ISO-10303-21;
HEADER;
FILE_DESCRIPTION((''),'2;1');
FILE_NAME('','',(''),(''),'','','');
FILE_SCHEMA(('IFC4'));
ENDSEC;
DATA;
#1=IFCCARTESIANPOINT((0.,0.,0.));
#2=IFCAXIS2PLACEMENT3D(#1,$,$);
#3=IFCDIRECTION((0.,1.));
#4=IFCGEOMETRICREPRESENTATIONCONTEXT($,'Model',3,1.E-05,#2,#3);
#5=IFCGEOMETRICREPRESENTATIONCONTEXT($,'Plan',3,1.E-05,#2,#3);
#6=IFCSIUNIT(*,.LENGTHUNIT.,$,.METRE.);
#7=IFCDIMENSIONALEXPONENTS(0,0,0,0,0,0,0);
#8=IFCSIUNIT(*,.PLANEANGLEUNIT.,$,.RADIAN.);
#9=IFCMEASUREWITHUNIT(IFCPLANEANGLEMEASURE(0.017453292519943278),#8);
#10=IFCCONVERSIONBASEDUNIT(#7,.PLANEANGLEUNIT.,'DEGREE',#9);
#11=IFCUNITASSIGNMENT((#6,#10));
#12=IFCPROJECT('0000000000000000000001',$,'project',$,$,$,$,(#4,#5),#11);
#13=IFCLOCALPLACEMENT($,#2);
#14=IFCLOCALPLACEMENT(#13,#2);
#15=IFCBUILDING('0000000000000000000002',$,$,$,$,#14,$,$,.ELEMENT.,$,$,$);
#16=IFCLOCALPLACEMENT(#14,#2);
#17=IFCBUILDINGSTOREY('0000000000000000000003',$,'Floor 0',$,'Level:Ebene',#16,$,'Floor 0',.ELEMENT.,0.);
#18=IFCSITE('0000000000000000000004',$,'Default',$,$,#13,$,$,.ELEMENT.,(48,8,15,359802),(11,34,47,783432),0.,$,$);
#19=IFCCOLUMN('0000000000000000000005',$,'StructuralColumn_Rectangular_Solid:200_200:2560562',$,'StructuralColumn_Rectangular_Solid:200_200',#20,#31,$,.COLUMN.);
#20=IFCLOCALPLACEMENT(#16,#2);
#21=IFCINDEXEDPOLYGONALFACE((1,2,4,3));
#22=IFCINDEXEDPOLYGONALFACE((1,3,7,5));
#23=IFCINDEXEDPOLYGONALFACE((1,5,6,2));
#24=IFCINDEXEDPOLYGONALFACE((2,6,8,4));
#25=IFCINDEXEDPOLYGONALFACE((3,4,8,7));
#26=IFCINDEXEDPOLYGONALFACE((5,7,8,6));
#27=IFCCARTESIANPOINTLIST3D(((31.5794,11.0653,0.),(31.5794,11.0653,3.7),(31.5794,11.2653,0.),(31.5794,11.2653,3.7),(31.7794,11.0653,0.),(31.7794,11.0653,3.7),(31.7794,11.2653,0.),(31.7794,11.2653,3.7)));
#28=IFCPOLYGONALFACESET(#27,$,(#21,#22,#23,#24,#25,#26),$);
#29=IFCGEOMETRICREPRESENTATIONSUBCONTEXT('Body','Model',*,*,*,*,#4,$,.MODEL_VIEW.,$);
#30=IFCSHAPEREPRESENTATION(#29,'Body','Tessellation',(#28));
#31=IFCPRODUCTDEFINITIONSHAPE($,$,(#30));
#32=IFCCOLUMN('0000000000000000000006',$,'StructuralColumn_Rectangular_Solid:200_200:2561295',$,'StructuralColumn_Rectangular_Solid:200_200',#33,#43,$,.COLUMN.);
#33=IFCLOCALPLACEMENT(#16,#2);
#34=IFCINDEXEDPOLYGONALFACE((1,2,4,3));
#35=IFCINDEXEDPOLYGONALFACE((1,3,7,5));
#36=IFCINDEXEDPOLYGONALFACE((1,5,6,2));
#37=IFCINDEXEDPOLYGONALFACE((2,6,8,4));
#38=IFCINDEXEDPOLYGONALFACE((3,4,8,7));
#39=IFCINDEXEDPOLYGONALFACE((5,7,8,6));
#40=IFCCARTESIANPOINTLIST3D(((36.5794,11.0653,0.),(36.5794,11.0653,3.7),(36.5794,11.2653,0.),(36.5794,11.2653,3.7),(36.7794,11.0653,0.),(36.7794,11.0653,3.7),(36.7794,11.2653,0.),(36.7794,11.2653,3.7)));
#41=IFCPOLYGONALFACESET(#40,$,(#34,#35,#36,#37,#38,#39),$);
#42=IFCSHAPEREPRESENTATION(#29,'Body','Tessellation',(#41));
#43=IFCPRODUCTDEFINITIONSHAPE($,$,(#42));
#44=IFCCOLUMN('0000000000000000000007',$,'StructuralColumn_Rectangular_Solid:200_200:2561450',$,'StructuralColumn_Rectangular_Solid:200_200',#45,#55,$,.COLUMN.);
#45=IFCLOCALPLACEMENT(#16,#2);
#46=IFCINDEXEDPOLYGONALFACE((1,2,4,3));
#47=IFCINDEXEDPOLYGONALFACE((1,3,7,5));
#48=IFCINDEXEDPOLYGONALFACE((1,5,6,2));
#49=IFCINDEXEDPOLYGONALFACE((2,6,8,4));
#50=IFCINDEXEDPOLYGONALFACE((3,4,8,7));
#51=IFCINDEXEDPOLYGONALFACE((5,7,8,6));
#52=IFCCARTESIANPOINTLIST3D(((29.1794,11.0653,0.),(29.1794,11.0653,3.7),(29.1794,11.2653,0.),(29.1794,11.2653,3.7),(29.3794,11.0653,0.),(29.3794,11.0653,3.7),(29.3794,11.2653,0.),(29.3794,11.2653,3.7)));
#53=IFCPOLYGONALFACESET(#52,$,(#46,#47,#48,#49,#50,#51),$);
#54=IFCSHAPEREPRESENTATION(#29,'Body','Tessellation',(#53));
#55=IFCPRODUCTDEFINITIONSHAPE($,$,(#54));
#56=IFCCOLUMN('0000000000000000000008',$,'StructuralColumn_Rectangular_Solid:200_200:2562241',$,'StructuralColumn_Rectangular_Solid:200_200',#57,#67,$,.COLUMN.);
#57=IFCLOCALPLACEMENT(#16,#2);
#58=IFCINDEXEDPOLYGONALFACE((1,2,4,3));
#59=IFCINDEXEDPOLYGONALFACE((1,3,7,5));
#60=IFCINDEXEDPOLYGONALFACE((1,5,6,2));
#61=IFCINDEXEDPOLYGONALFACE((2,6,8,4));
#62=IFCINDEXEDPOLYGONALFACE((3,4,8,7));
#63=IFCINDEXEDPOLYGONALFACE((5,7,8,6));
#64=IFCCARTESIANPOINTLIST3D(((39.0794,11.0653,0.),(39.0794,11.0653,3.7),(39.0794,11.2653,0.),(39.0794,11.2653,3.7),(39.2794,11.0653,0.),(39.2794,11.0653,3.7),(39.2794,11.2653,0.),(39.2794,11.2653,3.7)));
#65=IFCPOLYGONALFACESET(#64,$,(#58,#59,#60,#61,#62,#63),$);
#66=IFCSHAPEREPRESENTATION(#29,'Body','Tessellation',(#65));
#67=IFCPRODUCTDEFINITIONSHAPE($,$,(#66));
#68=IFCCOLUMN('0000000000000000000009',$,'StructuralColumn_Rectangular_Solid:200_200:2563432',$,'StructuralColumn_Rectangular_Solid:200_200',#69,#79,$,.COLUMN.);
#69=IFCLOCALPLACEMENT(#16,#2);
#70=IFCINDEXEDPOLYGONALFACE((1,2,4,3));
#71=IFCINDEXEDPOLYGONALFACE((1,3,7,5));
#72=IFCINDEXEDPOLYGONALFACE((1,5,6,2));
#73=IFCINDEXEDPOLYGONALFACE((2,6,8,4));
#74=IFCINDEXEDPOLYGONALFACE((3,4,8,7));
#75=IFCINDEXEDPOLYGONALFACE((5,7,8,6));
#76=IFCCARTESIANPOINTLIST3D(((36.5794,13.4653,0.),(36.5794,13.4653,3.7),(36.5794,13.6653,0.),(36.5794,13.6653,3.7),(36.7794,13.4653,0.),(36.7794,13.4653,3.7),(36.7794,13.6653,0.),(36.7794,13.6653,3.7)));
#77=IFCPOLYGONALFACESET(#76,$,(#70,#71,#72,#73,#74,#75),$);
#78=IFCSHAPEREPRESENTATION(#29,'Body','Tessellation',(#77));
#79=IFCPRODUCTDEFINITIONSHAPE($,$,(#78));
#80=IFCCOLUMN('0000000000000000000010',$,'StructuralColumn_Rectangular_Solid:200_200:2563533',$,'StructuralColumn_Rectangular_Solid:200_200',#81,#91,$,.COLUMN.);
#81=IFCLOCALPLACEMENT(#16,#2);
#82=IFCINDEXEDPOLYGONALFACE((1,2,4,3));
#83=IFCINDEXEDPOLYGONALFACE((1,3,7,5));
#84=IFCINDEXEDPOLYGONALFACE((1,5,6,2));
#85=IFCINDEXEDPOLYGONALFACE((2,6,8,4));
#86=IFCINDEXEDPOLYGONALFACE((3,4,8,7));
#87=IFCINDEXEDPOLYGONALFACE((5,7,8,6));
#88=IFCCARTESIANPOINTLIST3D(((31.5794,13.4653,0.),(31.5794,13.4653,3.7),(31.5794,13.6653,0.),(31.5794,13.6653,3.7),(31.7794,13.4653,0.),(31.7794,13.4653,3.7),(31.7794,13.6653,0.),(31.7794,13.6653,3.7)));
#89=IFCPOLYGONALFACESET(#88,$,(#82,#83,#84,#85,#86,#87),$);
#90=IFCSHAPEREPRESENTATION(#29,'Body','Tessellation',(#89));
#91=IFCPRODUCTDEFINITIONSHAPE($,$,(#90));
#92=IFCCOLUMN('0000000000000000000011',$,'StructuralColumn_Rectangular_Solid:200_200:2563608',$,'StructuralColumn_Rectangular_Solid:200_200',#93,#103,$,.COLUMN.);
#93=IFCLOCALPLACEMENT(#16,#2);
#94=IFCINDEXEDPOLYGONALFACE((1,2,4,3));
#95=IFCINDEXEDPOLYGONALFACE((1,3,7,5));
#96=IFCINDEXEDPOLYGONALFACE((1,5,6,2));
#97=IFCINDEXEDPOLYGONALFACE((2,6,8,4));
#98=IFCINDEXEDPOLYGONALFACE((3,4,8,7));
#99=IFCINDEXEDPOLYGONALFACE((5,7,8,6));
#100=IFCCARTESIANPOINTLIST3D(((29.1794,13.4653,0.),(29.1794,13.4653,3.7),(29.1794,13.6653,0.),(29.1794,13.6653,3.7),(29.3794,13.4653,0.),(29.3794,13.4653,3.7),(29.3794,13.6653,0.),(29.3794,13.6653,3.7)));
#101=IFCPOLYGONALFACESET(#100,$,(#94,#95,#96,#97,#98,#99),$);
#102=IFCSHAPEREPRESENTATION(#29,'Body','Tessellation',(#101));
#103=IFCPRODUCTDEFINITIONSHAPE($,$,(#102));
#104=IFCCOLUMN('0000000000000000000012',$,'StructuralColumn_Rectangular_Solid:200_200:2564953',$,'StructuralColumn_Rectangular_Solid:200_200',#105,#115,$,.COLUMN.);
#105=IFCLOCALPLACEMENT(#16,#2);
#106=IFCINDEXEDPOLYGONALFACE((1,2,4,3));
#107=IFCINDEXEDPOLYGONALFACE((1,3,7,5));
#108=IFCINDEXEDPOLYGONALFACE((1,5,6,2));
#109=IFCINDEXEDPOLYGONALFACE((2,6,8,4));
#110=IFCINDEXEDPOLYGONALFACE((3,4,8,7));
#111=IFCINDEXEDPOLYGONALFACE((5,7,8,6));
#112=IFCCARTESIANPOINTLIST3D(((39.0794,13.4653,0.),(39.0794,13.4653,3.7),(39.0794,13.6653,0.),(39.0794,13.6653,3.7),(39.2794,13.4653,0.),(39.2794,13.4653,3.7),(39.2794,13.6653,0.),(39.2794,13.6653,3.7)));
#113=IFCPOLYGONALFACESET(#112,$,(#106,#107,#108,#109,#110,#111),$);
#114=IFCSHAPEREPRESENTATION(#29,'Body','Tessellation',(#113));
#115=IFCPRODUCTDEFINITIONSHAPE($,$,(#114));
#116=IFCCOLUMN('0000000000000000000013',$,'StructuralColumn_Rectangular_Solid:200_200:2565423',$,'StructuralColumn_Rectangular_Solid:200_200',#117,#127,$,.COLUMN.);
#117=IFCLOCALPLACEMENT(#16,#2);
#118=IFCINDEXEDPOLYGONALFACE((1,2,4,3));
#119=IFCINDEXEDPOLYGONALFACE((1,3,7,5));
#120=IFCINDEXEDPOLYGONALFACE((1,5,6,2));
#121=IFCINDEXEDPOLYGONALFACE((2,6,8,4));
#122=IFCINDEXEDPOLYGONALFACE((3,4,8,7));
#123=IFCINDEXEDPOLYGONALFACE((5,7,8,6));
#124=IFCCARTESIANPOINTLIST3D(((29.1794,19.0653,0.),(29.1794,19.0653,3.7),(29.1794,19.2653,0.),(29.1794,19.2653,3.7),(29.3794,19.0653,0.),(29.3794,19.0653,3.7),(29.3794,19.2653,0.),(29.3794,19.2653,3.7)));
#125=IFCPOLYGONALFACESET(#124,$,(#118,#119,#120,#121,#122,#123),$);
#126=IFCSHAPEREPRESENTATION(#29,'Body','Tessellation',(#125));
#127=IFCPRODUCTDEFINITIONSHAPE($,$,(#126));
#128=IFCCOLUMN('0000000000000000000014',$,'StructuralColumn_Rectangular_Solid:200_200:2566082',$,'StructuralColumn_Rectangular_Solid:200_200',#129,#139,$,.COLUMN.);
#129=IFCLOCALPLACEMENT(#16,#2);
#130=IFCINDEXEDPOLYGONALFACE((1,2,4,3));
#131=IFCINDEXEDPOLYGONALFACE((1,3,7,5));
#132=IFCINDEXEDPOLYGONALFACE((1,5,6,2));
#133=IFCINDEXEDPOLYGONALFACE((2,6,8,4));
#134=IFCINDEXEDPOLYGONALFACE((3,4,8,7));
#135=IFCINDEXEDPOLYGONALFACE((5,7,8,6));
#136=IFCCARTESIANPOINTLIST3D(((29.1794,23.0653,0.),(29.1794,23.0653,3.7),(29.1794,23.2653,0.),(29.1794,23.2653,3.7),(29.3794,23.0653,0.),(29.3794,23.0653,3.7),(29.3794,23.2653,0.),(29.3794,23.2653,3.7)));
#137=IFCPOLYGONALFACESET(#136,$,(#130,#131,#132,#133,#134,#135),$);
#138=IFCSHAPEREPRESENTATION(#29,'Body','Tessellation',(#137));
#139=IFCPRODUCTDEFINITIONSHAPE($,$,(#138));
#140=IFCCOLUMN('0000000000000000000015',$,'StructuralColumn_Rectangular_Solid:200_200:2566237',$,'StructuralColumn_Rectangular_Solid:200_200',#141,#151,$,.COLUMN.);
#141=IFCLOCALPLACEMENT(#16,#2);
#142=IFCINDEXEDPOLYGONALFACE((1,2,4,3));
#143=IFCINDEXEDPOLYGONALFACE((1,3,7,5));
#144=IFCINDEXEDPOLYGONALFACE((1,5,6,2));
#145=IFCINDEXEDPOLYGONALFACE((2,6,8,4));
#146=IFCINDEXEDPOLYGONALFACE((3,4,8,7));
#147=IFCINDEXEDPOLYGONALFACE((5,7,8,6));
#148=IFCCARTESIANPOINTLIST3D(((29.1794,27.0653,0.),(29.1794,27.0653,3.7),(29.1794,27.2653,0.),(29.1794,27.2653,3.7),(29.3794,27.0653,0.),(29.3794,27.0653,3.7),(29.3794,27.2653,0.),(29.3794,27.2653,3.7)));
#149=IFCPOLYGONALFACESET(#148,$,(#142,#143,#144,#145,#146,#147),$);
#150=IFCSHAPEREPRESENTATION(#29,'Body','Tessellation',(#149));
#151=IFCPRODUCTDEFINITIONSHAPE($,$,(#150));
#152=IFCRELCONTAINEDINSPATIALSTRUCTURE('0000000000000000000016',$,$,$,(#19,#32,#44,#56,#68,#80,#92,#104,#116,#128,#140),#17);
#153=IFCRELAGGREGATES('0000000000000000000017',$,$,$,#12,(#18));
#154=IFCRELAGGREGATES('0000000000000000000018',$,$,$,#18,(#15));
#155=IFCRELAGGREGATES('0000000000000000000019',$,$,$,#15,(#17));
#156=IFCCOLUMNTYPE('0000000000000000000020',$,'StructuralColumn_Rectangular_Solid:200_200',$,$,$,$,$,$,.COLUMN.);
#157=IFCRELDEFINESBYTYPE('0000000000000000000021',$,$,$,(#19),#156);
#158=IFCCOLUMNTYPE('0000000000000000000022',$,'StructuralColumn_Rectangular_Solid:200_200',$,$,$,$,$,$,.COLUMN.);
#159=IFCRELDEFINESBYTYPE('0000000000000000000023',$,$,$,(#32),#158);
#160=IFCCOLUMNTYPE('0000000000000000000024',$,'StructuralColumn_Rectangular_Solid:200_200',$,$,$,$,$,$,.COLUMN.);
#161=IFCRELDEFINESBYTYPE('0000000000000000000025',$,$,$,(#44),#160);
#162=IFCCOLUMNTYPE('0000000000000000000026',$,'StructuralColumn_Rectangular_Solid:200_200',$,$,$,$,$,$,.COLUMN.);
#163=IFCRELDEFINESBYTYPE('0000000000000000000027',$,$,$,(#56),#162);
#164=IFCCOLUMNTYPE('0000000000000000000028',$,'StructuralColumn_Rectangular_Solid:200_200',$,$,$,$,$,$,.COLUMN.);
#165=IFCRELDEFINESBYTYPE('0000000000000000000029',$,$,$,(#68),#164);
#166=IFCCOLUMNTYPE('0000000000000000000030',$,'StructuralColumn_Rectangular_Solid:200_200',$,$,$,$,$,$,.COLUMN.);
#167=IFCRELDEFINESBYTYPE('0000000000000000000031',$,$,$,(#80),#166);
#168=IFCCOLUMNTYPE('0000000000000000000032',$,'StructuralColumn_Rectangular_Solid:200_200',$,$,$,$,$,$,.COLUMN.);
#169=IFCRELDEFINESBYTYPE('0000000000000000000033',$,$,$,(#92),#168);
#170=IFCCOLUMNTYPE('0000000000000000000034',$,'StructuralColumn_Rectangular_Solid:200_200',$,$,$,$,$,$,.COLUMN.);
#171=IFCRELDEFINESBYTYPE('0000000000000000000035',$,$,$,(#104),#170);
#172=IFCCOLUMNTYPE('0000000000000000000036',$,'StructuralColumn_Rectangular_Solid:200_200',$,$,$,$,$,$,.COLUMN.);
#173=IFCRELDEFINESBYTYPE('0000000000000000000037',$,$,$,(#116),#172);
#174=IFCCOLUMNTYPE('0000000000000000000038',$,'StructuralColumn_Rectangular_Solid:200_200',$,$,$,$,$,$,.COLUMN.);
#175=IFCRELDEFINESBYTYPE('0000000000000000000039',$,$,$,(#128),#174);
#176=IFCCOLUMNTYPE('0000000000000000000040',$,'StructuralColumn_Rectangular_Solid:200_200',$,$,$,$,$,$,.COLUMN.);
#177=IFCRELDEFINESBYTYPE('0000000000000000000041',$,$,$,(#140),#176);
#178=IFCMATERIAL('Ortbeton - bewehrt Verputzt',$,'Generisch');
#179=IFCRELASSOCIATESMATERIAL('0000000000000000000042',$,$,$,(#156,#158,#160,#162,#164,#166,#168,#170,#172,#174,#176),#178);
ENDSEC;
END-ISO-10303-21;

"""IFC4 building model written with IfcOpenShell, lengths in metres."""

from ifc_helpers import new_model, entity, si_unit, converted_unit, direction, frame, frame_2d, origin, origin_2d_with_axis, place, context, subcontext, project, spatial, rectangle, extrude, source, transform, mapped, material, material_profile, profile_set, type_object, type_shapes, element, save


model = new_model("IFC4")

# Units and contexts
model_context = context("Model", 3, precision=1e-05, world=origin(), true_north=direction((0.0, 1.0)))
plan_context = context("Plan", 3, precision=1e-05, world=origin(), true_north=direction((0.0, 1.0)))
body_context = subcontext(model_context, "Body", "Model", "MODEL_VIEW")
ifc_project = project(units=[si_unit("LENGTHUNIT", "METRE"), converted_unit("PLANEANGLEUNIT", "DEGREE", entity("IfcPlaneAngleMeasure", 0.017453292519943278), si_unit("PLANEANGLEUNIT", "RADIAN"), dimensions=[0, 0, 0, 0, 0, 0, 0])], contexts=[model_context, plan_context])

# Site, building, storey
site_placement = place(None, origin())
site = spatial("IfcSite", under=ifc_project, at=site_placement, Name="Default", CompositionType="ELEMENT", RefLatitude=(48, 8, 15, 359802), RefLongitude=(11, 34, 47, 783432), RefElevation=0.0)
building_placement = place(site_placement, origin())
building = spatial("IfcBuilding", under=site, at=building_placement, CompositionType="ELEMENT")
storey_placement = place(building_placement, origin())
storey = spatial("IfcBuildingStorey", under=building, at=storey_placement, Name="Floor 0", ObjectType="Level:Ebene", LongName="Floor 0", CompositionType="ELEMENT", Elevation=0.0)

# Columns
ifc_material_1 = material(Name="Ortbeton - bewehrt Verputzt", Category="Generisch")
ifc_material_profile = material_profile(ifc_material_1, rectangle(XDim=0.2, YDim=0.2, at=frame_2d((0.0, 0.0), x_axis=(1.0, 0.0))), Name="200_200")
ifc_profile_set = profile_set([ifc_material_profile], Name="200_200")
column_type_1 = type_object("IfcColumnType", Name="StructuralColumn_Rectangular_Solid:200_200", PredefinedType="COLUMN", material=ifc_profile_set)
shared_shape_1 = source(origin(), body_context, "Body", "SweptSolid", [
    extrude(rectangle(XDim=0.2, YDim=0.2, at=frame_2d((0.0, 0.0), x_axis=(1.0, 0.0))), frame((31.6794, 11.1653, 0.0), z_axis=(0.0, 0.0, 1.0), x_axis=(-1.0, 0.0, 0.0)), (0.0, 0.0, 1.0), 3.7),
])
type_shapes(column_type_1, [shared_shape_1])
column_1_placement = place(storey_placement, origin())
element("IfcColumn", 1, at=column_1_placement, inside=storey, type_object=column_type_1, Name="StructuralColumn_Rectangular_Solid:200_200:2560562", ObjectType="StructuralColumn_Rectangular_Solid:200_200", PredefinedType="COLUMN", context=body_context, shape_type="MappedRepresentation", body=[
    mapped(shared_shape_1, transform((0.0, 0.0, 0.0), scale=1.0)),
])
column_type_2 = type_object("IfcColumnType", Name="StructuralColumn_Rectangular_Solid:200_200", PredefinedType="COLUMN", material=ifc_profile_set)
shared_shape_2 = source(origin(), body_context, "Body", "SweptSolid", [
    extrude(rectangle(XDim=0.2, YDim=0.2, at=frame_2d((0.0, 0.0), x_axis=(1.0, 0.0))), frame((36.6794, 11.1653, 0.0), z_axis=(0.0, 0.0, 1.0), x_axis=(-1.0, 0.0, 0.0)), (0.0, 0.0, 1.0), 3.7),
])
type_shapes(column_type_2, [shared_shape_2])
column_2_placement = place(storey_placement, origin())
element("IfcColumn", 2, at=column_2_placement, inside=storey, type_object=column_type_2, Name="StructuralColumn_Rectangular_Solid:200_200:2561295", ObjectType="StructuralColumn_Rectangular_Solid:200_200", PredefinedType="COLUMN", context=body_context, shape_type="MappedRepresentation", body=[
    mapped(shared_shape_2, transform((0.0, 0.0, 0.0), scale=1.0)),
])
column_type_3 = type_object("IfcColumnType", Name="StructuralColumn_Rectangular_Solid:200_200", PredefinedType="COLUMN", material=ifc_profile_set)
shared_shape_3 = source(origin(), body_context, "Body", "SweptSolid", [
    extrude(rectangle(XDim=0.2, YDim=0.2, at=frame_2d((0.0, 0.0), x_axis=(1.0, 0.0))), frame((29.2794, 11.1653, 0.0), z_axis=(0.0, 0.0, 1.0), x_axis=(-1.0, 0.0, 0.0)), (0.0, 0.0, 1.0), 3.7),
])
type_shapes(column_type_3, [shared_shape_3])
column_3_placement = place(storey_placement, origin())
element("IfcColumn", 3, at=column_3_placement, inside=storey, type_object=column_type_3, Name="StructuralColumn_Rectangular_Solid:200_200:2561450", ObjectType="StructuralColumn_Rectangular_Solid:200_200", PredefinedType="COLUMN", context=body_context, shape_type="MappedRepresentation", body=[
    mapped(shared_shape_3, transform((0.0, 0.0, 0.0), scale=1.0)),
])
column_type_4 = type_object("IfcColumnType", Name="StructuralColumn_Rectangular_Solid:200_200", PredefinedType="COLUMN", material=ifc_profile_set)
shared_shape_4 = source(origin(), body_context, "Body", "SweptSolid", [
    extrude(rectangle(XDim=0.2, YDim=0.2, at=frame_2d((0.0, 0.0), x_axis=(1.0, 0.0))), frame((39.1794, 11.1653, 0.0), z_axis=(0.0, 0.0, 1.0), x_axis=(-1.0, 0.0, 0.0)), (0.0, 0.0, 1.0), 3.7),
])
type_shapes(column_type_4, [shared_shape_4])
column_4_placement = place(storey_placement, origin())
element("IfcColumn", 4, at=column_4_placement, inside=storey, type_object=column_type_4, Name="StructuralColumn_Rectangular_Solid:200_200:2562241", ObjectType="StructuralColumn_Rectangular_Solid:200_200", PredefinedType="COLUMN", context=body_context, shape_type="MappedRepresentation", body=[
    mapped(shared_shape_4, transform((0.0, 0.0, 0.0), scale=1.0)),
])
column_type_5 = type_object("IfcColumnType", Name="StructuralColumn_Rectangular_Solid:200_200", PredefinedType="COLUMN", material=ifc_profile_set)
shared_shape_5 = source(origin(), body_context, "Body", "SweptSolid", [
    extrude(rectangle(XDim=0.2, YDim=0.2, at=frame_2d((0.0, 0.0), x_axis=(1.0, 0.0))), frame((36.6794, 13.5653, 0.0), z_axis=(0.0, 0.0, 1.0), x_axis=(-1.0, 0.0, 0.0)), (0.0, 0.0, 1.0), 3.7),
])
type_shapes(column_type_5, [shared_shape_5])
column_5_placement = place(storey_placement, origin())
element("IfcColumn", 5, at=column_5_placement, inside=storey, type_object=column_type_5, Name="StructuralColumn_Rectangular_Solid:200_200:2563432", ObjectType="StructuralColumn_Rectangular_Solid:200_200", PredefinedType="COLUMN", context=body_context, shape_type="MappedRepresentation", body=[
    mapped(shared_shape_5, transform((0.0, 0.0, 0.0), scale=1.0)),
])
column_type_6 = type_object("IfcColumnType", Name="StructuralColumn_Rectangular_Solid:200_200", PredefinedType="COLUMN", material=ifc_profile_set)
shared_shape_6 = source(origin(), body_context, "Body", "SweptSolid", [
    extrude(rectangle(XDim=0.2, YDim=0.2, at=frame_2d((0.0, 0.0), x_axis=(1.0, 0.0))), frame((31.6794, 13.5653, 0.0), z_axis=(0.0, 0.0, 1.0), x_axis=(-1.0, 0.0, 0.0)), (0.0, 0.0, 1.0), 3.7),
])
type_shapes(column_type_6, [shared_shape_6])
column_6_placement = place(storey_placement, origin())
element("IfcColumn", 6, at=column_6_placement, inside=storey, type_object=column_type_6, Name="StructuralColumn_Rectangular_Solid:200_200:2563533", ObjectType="StructuralColumn_Rectangular_Solid:200_200", PredefinedType="COLUMN", context=body_context, shape_type="MappedRepresentation", body=[
    mapped(shared_shape_6, transform((0.0, 0.0, 0.0), scale=1.0)),
])
column_type_7 = type_object("IfcColumnType", Name="StructuralColumn_Rectangular_Solid:200_200", PredefinedType="COLUMN", material=ifc_profile_set)
shared_shape_7 = source(origin(), body_context, "Body", "SweptSolid", [
    extrude(rectangle(XDim=0.2, YDim=0.2, at=frame_2d((0.0, 0.0), x_axis=(1.0, 0.0))), frame((29.2794, 13.5653, 0.0), z_axis=(0.0, 0.0, 1.0), x_axis=(-1.0, 0.0, 0.0)), (0.0, 0.0, 1.0), 3.7),
])
type_shapes(column_type_7, [shared_shape_7])
column_7_placement = place(storey_placement, origin())
element("IfcColumn", 7, at=column_7_placement, inside=storey, type_object=column_type_7, Name="StructuralColumn_Rectangular_Solid:200_200:2563608", ObjectType="StructuralColumn_Rectangular_Solid:200_200", PredefinedType="COLUMN", context=body_context, shape_type="MappedRepresentation", body=[
    mapped(shared_shape_7, transform((0.0, 0.0, 0.0), scale=1.0)),
])
column_type_8 = type_object("IfcColumnType", Name="StructuralColumn_Rectangular_Solid:200_200", PredefinedType="COLUMN", material=ifc_profile_set)
shared_shape_8 = source(origin(), body_context, "Body", "SweptSolid", [
    extrude(rectangle(XDim=0.2, YDim=0.2, at=frame_2d((0.0, 0.0), x_axis=(1.0, 0.0))), frame((39.1794, 13.5653, 0.0), z_axis=(0.0, 0.0, 1.0), x_axis=(-1.0, 0.0, 0.0)), (0.0, 0.0, 1.0), 3.7),
])
type_shapes(column_type_8, [shared_shape_8])
column_8_placement = place(storey_placement, origin())
element("IfcColumn", 8, at=column_8_placement, inside=storey, type_object=column_type_8, Name="StructuralColumn_Rectangular_Solid:200_200:2564953", ObjectType="StructuralColumn_Rectangular_Solid:200_200", PredefinedType="COLUMN", context=body_context, shape_type="MappedRepresentation", body=[
    mapped(shared_shape_8, transform((0.0, 0.0, 0.0), scale=1.0)),
])
column_type_9 = type_object("IfcColumnType", Name="StructuralColumn_Rectangular_Solid:200_200", PredefinedType="COLUMN", material=ifc_profile_set)
shared_shape_9 = source(origin(), body_context, "Body", "SweptSolid", [
    extrude(rectangle(XDim=0.2, YDim=0.2, at=frame_2d((0.0, 0.0), x_axis=(1.0, 0.0))), frame((29.2794, 19.1653, 0.0), z_axis=(0.0, 0.0, 1.0), x_axis=(-1.0, 0.0, 0.0)), (0.0, 0.0, 1.0), 3.7),
])
type_shapes(column_type_9, [shared_shape_9])
column_9_placement = place(storey_placement, origin())
element("IfcColumn", 9, at=column_9_placement, inside=storey, type_object=column_type_9, Name="StructuralColumn_Rectangular_Solid:200_200:2565423", ObjectType="StructuralColumn_Rectangular_Solid:200_200", PredefinedType="COLUMN", context=body_context, shape_type="MappedRepresentation", body=[
    mapped(shared_shape_9, transform((0.0, 0.0, 0.0), scale=1.0)),
])
column_type_10 = type_object("IfcColumnType", Name="StructuralColumn_Rectangular_Solid:200_200", PredefinedType="COLUMN", material=ifc_profile_set)
shared_shape_10 = source(origin(), body_context, "Body", "SweptSolid", [
    extrude(rectangle(XDim=0.2, YDim=0.2, at=origin_2d_with_axis()), frame((29.2794, 23.1653, 0.0), z_axis=(0.0, 0.0, 1.0), x_axis=(-1.0, 0.0, 0.0)), (0.0, 0.0, 1.0), 3.7),
])
type_shapes(column_type_10, [shared_shape_10])
column_10_placement = place(storey_placement, origin())
element("IfcColumn", 10, at=column_10_placement, inside=storey, type_object=column_type_10, Name="StructuralColumn_Rectangular_Solid:200_200:2566082", ObjectType="StructuralColumn_Rectangular_Solid:200_200", PredefinedType="COLUMN", context=body_context, shape_type="MappedRepresentation", body=[
    mapped(shared_shape_10, transform((0.0, 0.0, 0.0), scale=1.0)),
])
column_type_11 = type_object("IfcColumnType", Name="StructuralColumn_Rectangular_Solid:200_200", PredefinedType="COLUMN", material=ifc_profile_set)
shared_shape_11 = source(origin(), body_context, "Body", "SweptSolid", [
    extrude(rectangle(XDim=0.2, YDim=0.2, at=frame_2d((0.0, 0.0), x_axis=(1.0, 0.0))), frame((29.2794, 27.1653, 0.0), z_axis=(0.0, 0.0, 1.0), x_axis=(-1.0, 0.0, 0.0)), (0.0, 0.0, 1.0), 3.7),
])
type_shapes(column_type_11, [shared_shape_11])
column_11_placement = place(storey_placement, origin())
element("IfcColumn", 11, at=column_11_placement, inside=storey, type_object=column_type_11, Name="StructuralColumn_Rectangular_Solid:200_200:2566237", ObjectType="StructuralColumn_Rectangular_Solid:200_200", PredefinedType="COLUMN", context=body_context, shape_type="MappedRepresentation", body=[
    mapped(shared_shape_11, transform((0.0, 0.0, 0.0), scale=1.0)),
])

save(model, "model.ifc")
